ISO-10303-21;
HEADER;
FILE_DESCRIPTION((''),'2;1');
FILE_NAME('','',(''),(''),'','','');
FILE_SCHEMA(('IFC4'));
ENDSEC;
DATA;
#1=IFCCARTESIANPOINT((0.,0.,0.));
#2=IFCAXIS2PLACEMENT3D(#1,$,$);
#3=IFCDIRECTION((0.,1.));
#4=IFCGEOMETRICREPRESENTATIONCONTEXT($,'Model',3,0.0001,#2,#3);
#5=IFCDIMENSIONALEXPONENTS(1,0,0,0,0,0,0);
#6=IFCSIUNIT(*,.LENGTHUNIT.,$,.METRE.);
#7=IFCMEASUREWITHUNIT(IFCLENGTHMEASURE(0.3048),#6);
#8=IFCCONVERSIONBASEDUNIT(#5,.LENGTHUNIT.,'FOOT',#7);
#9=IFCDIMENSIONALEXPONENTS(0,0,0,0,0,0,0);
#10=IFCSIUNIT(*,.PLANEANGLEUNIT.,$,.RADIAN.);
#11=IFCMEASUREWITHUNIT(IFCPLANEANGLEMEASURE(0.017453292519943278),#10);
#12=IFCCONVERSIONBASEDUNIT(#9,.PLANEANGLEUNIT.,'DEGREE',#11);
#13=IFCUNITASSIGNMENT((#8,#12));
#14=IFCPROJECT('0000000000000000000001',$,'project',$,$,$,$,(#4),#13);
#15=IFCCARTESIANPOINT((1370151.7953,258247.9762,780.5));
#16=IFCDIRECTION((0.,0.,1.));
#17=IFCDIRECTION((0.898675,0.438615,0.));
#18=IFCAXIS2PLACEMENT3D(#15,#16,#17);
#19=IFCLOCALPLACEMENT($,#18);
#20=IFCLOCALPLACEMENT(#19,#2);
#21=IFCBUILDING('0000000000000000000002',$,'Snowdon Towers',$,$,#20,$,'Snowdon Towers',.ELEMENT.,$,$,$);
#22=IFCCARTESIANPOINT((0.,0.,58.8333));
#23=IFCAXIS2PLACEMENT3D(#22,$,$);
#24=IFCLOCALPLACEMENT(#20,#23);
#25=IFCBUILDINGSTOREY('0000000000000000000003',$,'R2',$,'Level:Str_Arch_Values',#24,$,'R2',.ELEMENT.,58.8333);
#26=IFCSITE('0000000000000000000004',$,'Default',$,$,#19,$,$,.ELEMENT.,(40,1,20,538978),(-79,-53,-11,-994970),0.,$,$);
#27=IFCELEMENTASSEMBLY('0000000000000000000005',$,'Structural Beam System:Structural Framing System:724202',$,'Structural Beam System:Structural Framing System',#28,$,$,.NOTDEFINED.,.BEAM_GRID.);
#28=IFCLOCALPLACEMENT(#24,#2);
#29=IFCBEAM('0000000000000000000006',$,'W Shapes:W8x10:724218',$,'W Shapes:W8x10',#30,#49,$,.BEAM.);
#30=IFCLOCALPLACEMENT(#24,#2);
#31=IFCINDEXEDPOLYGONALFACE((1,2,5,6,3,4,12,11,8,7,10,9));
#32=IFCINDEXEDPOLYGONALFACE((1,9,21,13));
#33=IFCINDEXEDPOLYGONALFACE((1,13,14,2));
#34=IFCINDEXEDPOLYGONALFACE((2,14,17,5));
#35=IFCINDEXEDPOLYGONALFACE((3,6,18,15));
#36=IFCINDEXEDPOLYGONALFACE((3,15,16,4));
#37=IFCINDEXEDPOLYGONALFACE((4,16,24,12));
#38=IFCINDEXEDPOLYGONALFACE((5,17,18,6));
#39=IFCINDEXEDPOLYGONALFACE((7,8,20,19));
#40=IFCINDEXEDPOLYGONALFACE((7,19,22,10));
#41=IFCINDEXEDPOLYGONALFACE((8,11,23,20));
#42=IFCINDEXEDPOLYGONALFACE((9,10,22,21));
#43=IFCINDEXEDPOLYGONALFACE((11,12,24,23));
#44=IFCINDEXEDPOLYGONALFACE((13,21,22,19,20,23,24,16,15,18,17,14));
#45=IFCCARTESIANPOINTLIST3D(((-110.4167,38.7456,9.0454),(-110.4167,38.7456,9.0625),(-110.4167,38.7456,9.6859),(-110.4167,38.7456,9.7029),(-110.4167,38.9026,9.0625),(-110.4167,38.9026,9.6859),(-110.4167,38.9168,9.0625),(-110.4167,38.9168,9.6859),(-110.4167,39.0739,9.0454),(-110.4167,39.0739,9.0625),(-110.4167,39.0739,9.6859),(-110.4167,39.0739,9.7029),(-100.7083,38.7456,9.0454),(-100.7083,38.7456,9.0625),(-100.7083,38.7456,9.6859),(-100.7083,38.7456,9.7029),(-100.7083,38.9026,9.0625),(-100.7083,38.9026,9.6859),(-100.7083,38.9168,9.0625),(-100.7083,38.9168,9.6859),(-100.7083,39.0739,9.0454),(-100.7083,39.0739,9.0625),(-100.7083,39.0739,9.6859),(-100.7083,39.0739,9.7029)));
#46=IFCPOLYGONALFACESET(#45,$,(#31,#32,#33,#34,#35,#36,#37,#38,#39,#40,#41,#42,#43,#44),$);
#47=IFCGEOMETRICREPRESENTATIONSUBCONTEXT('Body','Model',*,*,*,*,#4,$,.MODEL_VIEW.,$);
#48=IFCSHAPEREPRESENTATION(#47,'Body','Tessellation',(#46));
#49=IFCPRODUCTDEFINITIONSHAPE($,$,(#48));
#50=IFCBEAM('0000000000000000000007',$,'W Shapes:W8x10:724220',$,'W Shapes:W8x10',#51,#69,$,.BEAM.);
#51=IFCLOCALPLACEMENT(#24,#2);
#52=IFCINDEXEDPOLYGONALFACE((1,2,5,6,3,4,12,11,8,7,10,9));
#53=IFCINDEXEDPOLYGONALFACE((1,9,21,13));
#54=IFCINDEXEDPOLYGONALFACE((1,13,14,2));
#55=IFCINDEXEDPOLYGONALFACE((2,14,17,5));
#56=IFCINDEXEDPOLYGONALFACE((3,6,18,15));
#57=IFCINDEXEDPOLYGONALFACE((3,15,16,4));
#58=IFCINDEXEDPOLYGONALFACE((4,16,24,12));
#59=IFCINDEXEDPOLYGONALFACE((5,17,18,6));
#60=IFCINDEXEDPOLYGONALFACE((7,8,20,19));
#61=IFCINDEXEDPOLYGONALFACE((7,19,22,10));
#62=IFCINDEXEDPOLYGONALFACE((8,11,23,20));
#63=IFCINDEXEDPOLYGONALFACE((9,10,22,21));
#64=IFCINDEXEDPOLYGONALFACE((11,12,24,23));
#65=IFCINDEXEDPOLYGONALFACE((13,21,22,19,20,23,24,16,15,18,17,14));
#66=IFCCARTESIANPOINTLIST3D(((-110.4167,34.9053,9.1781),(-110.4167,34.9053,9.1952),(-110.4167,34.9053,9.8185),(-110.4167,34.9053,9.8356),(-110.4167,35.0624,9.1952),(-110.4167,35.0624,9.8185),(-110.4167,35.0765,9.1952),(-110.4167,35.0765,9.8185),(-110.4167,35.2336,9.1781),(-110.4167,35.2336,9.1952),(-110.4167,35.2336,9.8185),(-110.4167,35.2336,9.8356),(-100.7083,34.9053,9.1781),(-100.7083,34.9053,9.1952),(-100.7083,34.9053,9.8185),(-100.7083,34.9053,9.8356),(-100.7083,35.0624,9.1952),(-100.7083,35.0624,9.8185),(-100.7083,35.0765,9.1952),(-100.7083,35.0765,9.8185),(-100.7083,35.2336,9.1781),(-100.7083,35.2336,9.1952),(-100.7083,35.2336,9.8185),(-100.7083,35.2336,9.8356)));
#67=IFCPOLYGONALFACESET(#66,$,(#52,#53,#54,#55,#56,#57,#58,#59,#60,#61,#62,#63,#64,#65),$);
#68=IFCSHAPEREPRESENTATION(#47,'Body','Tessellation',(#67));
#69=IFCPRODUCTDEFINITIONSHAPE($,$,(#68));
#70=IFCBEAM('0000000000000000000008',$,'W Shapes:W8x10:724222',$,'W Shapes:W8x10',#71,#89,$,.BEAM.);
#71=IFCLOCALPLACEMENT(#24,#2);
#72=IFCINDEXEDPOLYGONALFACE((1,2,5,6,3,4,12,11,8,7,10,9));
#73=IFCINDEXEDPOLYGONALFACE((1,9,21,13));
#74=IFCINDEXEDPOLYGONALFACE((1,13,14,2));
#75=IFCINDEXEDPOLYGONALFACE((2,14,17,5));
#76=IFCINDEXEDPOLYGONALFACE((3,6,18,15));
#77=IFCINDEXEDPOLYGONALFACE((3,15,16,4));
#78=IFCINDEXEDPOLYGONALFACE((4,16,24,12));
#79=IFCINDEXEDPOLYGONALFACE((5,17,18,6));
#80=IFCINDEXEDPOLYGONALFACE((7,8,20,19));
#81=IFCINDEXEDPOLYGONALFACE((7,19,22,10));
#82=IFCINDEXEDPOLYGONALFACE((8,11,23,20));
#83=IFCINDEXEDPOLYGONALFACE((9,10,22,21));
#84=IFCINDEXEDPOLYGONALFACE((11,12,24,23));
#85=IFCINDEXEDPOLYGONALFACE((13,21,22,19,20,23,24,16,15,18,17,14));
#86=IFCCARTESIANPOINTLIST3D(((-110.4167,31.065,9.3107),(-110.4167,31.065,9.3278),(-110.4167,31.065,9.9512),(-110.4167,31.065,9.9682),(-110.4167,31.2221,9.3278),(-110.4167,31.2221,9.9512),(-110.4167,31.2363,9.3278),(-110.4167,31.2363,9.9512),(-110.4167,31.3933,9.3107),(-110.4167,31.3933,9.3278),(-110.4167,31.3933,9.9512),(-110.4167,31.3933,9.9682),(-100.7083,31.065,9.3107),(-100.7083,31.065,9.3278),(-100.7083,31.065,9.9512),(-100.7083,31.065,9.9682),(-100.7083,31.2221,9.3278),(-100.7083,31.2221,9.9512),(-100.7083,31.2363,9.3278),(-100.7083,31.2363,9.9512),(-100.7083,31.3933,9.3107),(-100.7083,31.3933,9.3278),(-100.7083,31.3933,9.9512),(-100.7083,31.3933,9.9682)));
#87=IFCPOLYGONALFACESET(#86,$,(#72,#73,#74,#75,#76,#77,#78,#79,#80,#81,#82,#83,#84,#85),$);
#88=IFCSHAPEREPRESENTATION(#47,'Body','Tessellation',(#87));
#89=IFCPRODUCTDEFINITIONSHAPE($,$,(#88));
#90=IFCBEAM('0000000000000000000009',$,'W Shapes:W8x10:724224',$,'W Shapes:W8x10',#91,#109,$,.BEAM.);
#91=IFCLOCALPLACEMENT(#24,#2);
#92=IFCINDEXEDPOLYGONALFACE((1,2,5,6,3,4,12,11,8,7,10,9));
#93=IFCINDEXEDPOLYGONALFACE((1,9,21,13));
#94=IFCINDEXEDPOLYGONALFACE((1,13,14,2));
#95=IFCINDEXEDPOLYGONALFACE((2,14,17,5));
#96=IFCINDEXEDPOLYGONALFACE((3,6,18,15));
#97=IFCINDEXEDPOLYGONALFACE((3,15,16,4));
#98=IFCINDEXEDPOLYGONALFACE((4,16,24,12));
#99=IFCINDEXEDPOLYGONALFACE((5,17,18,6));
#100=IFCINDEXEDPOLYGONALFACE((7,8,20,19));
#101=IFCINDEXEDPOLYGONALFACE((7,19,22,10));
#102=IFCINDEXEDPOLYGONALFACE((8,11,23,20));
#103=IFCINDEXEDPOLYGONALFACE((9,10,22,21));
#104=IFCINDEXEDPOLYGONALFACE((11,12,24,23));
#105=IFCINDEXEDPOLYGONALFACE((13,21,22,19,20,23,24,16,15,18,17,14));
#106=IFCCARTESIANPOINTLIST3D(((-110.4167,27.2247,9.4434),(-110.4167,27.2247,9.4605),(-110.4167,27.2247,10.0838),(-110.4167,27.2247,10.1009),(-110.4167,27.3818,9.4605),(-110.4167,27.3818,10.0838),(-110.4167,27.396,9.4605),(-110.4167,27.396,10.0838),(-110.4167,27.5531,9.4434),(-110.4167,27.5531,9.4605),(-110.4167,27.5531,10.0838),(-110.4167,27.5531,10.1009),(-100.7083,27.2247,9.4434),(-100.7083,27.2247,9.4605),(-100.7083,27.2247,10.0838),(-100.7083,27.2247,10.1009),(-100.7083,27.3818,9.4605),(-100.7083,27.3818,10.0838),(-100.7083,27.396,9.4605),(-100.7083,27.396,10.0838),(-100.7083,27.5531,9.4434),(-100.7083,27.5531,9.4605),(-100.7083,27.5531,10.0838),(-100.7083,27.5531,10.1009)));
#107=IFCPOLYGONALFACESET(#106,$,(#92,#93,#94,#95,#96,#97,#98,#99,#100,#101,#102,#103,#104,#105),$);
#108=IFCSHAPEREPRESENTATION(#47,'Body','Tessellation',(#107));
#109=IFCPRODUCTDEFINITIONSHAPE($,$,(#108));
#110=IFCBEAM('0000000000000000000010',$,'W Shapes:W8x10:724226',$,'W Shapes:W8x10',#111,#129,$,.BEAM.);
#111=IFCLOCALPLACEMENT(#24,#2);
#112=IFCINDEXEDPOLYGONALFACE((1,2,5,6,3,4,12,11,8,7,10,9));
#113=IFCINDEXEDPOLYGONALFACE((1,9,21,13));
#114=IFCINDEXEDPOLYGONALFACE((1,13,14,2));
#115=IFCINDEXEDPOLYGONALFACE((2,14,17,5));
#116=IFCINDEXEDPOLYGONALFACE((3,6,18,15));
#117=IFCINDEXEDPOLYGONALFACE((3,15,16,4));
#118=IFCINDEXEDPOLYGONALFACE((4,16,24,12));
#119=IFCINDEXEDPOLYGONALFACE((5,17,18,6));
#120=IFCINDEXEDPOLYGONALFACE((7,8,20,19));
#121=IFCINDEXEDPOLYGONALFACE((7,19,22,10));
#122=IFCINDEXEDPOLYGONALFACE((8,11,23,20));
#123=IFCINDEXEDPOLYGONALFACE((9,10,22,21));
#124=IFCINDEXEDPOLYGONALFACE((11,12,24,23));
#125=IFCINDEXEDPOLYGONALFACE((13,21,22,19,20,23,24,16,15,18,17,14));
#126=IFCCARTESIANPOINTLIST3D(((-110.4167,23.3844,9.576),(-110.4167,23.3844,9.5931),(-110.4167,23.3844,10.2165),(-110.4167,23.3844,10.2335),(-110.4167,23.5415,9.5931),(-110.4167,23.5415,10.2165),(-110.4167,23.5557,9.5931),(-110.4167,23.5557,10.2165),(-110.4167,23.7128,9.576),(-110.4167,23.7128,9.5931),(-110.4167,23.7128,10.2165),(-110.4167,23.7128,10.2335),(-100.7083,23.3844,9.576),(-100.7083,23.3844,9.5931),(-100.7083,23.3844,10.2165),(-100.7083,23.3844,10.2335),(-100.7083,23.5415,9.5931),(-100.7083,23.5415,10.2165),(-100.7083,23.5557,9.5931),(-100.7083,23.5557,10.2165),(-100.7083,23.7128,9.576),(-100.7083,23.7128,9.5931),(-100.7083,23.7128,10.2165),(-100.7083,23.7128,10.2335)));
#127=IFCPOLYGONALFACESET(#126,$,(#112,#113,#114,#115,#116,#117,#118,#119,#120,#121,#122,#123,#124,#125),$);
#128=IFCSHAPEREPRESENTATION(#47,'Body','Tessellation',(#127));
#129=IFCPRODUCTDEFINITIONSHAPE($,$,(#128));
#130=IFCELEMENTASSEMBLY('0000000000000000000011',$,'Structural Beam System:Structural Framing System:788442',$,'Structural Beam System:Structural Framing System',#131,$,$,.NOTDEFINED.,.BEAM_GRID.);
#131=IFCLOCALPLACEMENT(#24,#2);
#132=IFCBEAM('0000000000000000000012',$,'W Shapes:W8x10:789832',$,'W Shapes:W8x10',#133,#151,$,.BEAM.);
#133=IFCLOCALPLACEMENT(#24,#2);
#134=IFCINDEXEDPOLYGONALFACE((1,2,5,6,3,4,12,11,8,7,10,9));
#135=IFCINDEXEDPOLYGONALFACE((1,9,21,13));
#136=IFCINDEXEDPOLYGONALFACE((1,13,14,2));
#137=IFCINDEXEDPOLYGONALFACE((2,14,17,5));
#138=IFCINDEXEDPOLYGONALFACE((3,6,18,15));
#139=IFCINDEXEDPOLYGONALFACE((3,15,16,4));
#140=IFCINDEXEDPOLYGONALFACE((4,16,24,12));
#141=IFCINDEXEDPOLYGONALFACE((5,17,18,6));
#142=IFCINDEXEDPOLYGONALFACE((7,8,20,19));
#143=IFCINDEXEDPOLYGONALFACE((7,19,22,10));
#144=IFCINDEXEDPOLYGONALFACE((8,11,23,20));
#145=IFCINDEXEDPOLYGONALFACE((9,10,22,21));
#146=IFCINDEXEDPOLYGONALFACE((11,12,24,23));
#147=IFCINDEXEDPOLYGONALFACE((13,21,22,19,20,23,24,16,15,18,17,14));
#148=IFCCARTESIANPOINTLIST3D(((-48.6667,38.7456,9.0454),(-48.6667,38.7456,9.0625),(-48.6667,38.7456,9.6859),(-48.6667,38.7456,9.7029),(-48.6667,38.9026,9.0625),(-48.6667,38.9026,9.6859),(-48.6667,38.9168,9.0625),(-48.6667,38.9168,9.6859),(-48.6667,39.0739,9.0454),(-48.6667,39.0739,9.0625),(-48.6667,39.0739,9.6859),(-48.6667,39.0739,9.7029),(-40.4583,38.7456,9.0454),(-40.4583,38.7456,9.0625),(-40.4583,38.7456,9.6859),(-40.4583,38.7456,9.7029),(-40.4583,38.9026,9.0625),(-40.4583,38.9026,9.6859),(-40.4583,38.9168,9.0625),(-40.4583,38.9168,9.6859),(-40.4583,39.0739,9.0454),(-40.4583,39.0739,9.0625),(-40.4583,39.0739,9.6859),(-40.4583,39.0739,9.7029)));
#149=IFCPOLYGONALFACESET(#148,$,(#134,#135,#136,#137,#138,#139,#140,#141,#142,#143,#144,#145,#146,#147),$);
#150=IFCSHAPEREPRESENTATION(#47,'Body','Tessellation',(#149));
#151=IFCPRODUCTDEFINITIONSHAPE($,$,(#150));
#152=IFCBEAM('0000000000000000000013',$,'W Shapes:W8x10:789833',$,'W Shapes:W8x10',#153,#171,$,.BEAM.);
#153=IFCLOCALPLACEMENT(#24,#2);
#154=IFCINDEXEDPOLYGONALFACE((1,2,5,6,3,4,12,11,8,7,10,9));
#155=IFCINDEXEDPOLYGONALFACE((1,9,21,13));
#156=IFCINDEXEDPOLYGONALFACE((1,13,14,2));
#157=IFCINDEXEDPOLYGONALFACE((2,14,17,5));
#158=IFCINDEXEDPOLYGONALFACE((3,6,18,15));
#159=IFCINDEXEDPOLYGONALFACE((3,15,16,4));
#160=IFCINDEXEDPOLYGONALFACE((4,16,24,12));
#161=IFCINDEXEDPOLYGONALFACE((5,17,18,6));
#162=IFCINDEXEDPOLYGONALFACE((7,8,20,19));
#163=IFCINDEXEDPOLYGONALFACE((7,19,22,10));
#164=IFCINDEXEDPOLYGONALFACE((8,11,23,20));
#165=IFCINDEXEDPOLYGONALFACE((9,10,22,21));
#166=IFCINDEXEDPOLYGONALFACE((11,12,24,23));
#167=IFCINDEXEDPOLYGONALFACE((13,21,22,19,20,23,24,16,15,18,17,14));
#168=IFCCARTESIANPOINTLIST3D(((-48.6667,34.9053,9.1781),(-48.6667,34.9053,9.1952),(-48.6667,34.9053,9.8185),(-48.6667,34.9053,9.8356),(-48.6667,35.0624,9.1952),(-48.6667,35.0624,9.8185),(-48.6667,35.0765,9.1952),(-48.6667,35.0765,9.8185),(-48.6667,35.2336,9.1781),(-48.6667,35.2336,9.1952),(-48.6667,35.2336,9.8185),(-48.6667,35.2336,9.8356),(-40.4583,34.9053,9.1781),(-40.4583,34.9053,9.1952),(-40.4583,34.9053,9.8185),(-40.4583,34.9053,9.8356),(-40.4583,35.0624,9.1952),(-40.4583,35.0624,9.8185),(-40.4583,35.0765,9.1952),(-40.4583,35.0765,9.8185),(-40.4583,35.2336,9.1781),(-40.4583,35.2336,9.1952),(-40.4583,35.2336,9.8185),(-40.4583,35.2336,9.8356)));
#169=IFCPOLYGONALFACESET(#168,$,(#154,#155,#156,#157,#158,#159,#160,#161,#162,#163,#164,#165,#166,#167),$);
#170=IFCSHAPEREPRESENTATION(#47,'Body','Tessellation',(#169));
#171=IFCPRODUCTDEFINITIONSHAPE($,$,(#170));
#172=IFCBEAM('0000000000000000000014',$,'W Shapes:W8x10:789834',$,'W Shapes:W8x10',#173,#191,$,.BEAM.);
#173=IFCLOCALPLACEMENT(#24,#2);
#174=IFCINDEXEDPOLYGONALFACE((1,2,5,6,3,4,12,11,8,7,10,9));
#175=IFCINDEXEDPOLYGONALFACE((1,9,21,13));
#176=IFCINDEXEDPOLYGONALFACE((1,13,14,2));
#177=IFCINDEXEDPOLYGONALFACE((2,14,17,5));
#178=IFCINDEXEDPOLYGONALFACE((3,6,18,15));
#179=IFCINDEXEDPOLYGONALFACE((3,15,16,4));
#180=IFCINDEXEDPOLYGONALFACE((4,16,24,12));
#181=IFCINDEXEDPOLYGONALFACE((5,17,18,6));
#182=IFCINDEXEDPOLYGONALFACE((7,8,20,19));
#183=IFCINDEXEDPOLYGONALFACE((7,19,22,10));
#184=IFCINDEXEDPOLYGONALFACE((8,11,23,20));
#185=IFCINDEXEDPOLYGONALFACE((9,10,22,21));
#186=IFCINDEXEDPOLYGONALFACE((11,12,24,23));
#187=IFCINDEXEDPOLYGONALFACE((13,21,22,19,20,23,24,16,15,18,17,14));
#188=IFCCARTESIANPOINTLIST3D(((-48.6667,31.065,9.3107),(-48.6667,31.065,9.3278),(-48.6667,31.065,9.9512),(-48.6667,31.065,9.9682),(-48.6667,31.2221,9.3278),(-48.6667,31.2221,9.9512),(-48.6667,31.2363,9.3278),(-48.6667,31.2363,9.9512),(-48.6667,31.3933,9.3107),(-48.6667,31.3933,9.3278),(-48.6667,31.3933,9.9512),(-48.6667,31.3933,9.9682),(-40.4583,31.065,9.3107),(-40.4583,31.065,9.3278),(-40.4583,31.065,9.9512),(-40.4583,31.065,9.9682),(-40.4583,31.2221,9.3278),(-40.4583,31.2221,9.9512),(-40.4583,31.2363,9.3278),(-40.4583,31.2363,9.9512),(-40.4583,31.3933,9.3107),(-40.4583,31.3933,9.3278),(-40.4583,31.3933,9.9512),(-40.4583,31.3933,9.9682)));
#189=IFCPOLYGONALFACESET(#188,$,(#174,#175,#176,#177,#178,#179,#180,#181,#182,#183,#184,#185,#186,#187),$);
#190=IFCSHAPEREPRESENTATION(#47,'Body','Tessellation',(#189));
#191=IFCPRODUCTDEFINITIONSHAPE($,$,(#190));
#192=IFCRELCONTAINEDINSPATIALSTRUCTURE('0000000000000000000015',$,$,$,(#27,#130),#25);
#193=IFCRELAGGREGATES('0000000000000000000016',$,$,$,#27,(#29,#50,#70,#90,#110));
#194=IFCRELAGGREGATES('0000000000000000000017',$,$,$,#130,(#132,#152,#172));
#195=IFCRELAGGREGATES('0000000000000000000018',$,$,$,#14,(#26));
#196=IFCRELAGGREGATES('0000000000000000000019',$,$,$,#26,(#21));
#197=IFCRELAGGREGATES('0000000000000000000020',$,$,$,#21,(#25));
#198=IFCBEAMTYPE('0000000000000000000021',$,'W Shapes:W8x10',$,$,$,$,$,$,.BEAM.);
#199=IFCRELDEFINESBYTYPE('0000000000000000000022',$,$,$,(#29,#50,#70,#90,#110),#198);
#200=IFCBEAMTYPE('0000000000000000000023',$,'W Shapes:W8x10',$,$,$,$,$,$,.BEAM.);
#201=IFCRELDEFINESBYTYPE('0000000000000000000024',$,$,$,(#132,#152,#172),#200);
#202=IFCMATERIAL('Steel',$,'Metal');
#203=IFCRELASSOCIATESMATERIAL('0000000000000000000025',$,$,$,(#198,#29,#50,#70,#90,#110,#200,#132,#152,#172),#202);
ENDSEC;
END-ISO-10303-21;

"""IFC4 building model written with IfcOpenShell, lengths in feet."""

from ifc_helpers import new_model, entity, si_unit, converted_unit, direction, frame, origin, place, context, subcontext, project, spatial, indexed_curve, outline, extrude, source, transform, mapped, material, type_object, type_shapes, element, aggregate, save


model = new_model("IFC4")

# Units and contexts
model_context = context("Model", 3, precision=0.0001, world=origin(), true_north=direction((0.0, 1.0)))
body_context = subcontext(model_context, "Body", "Model", "MODEL_VIEW")
ifc_project = project(units=[converted_unit("LENGTHUNIT", "FOOT", entity("IfcLengthMeasure", 0.3048), si_unit("LENGTHUNIT", "METRE"), dimensions=[1, 0, 0, 0, 0, 0, 0]), converted_unit("PLANEANGLEUNIT", "DEGREE", entity("IfcPlaneAngleMeasure", 0.017453292519943278), si_unit("PLANEANGLEUNIT", "RADIAN"), dimensions=[0, 0, 0, 0, 0, 0, 0])], contexts=[model_context])

# Site, building, storey
site_placement = place(None, frame((1370151.7953, 258247.9762, 780.5), z_axis=(0.0, 0.0, 1.0), x_axis=(0.898675, 0.438615, 0.0)))
site = spatial("IfcSite", under=ifc_project, at=site_placement, Name="Default", CompositionType="ELEMENT", RefLatitude=(40, 1, 20, 538978), RefLongitude=(-79, -53, -11, -994970), RefElevation=0.0)
building_placement = place(site_placement, origin())
building = spatial("IfcBuilding", under=site, at=building_placement, Name="Snowdon Towers", LongName="Snowdon Towers", CompositionType="ELEMENT")
storey_placement = place(building_placement, frame((0.0, 0.0, 58.8333)))
storey = spatial("IfcBuildingStorey", under=building, at=storey_placement, Name="R2", ObjectType="Level:Str_Arch_Values", LongName="R2", CompositionType="ELEMENT", Elevation=58.8333)

# Element assemblies, beams
assembly_1_placement = place(storey_placement, origin())
assembly_1 = element("IfcElementAssembly", 1, at=assembly_1_placement, inside=storey, Name="Structural Beam System:Structural Framing System:724202", ObjectType="Structural Beam System:Structural Framing System", AssemblyPlace="NOTDEFINED", PredefinedType="BEAM_GRID")
ifc_material_1 = material(Name="Steel", Category="Metal")
beam_type_1 = type_object("IfcBeamType", Name="W Shapes:W8x10", PredefinedType="BEAM", material=ifc_material_1)
shared_shape_1 = source(origin(), body_context, "Body", "SweptSolid", [
    extrude(outline(indexed_curve([(-0.1642, -0.3117), (-0.1642, -0.3288), (0.1642, -0.3288), (0.1642, -0.3117), (0.0071, -0.3117), (0.0071, 0.3117), (0.1642, 0.3117), (0.1642, 0.3287), (-0.1642, 0.3287), (-0.1642, 0.3117), (-0.0071, 0.3117), (-0.0071, -0.3117), (-0.1642, -0.3117)], self_intersect=False)), frame((-4.8542, 0.0, 0.0), z_axis=(-1.0, 0.0, 0.0), x_axis=(0.0, -1.0, 0.0)), (0.0, 0.0, -1.0), 9.7083),
])
type_shapes(beam_type_1, [shared_shape_1])
beam_1_placement = place(assembly_1_placement, frame((-105.5625, 38.9097, 9.3742)))
beam_1 = element("IfcBeam", 2, at=beam_1_placement, type_object=beam_type_1, material=ifc_material_1, Name="W Shapes:W8x10:724218", ObjectType="W Shapes:W8x10", PredefinedType="BEAM", context=body_context, shape_type="MappedRepresentation", body=[
    mapped(shared_shape_1, transform((0.0, 0.0, 0.0), scale=1.0)),
])
beam_2_placement = place(assembly_1_placement, frame((-105.5625, 35.0694, 9.5068)))
beam_2 = element("IfcBeam", 3, at=beam_2_placement, type_object=beam_type_1, material=ifc_material_1, Name="W Shapes:W8x10:724220", ObjectType="W Shapes:W8x10", PredefinedType="BEAM", context=body_context, shape_type="MappedRepresentation", body=[
    mapped(shared_shape_1, transform((0.0, 0.0, 0.0), scale=1.0)),
])
beam_3_placement = place(assembly_1_placement, frame((-105.5625, 31.2292, 9.6395)))
beam_3 = element("IfcBeam", 4, at=beam_3_placement, type_object=beam_type_1, material=ifc_material_1, Name="W Shapes:W8x10:724222", ObjectType="W Shapes:W8x10", PredefinedType="BEAM", context=body_context, shape_type="MappedRepresentation", body=[
    mapped(shared_shape_1, transform((0.0, 0.0, 0.0), scale=1.0)),
])
beam_4_placement = place(assembly_1_placement, frame((-105.5625, 27.3889, 9.7721)))
beam_4 = element("IfcBeam", 5, at=beam_4_placement, type_object=beam_type_1, material=ifc_material_1, Name="W Shapes:W8x10:724224", ObjectType="W Shapes:W8x10", PredefinedType="BEAM", context=body_context, shape_type="MappedRepresentation", body=[
    mapped(shared_shape_1, transform((0.0, 0.0, 0.0), scale=1.0)),
])
beam_5_placement = place(assembly_1_placement, frame((-105.5625, 23.5486, 9.9048)))
beam_5 = element("IfcBeam", 6, at=beam_5_placement, type_object=beam_type_1, material=ifc_material_1, Name="W Shapes:W8x10:724226", ObjectType="W Shapes:W8x10", PredefinedType="BEAM", context=body_context, shape_type="MappedRepresentation", body=[
    mapped(shared_shape_1, transform((0.0, 0.0, 0.0), scale=1.0)),
])
aggregate(assembly_1, [beam_1, beam_2, beam_3, beam_4, beam_5])
assembly_2_placement = place(storey_placement, origin())
assembly_2 = element("IfcElementAssembly", 7, at=assembly_2_placement, inside=storey, Name="Structural Beam System:Structural Framing System:788442", ObjectType="Structural Beam System:Structural Framing System", AssemblyPlace="NOTDEFINED", PredefinedType="BEAM_GRID")
beam_type_2 = type_object("IfcBeamType", Name="W Shapes:W8x10", PredefinedType="BEAM", material=ifc_material_1)
shared_shape_2 = source(origin(), body_context, "Body", "SweptSolid", [
    extrude(outline(indexed_curve([(-0.1642, -0.3117), (-0.1642, -0.3288), (0.1642, -0.3288), (0.1642, -0.3117), (0.0071, -0.3117), (0.0071, 0.3117), (0.1642, 0.3117), (0.1642, 0.3287), (-0.1642, 0.3287), (-0.1642, 0.3117), (-0.0071, 0.3117), (-0.0071, -0.3117), (-0.1642, -0.3117)], self_intersect=False)), frame((-4.1042, 0.0, 0.0), z_axis=(-1.0, 0.0, 0.0), x_axis=(0.0, -1.0, 0.0)), (0.0, 0.0, -1.0), 8.2083),
])
type_shapes(beam_type_2, [shared_shape_2])
beam_6_placement = place(assembly_2_placement, frame((-44.5625, 38.9097, 9.3742)))
beam_6 = element("IfcBeam", 8, at=beam_6_placement, type_object=beam_type_2, material=ifc_material_1, Name="W Shapes:W8x10:789832", ObjectType="W Shapes:W8x10", PredefinedType="BEAM", context=body_context, shape_type="MappedRepresentation", body=[
    mapped(shared_shape_2, transform((0.0, 0.0, 0.0), scale=1.0)),
])
beam_7_placement = place(assembly_2_placement, frame((-44.5625, 35.0694, 9.5068)))
beam_7 = element("IfcBeam", 9, at=beam_7_placement, type_object=beam_type_2, material=ifc_material_1, Name="W Shapes:W8x10:789833", ObjectType="W Shapes:W8x10", PredefinedType="BEAM", context=body_context, shape_type="MappedRepresentation", body=[
    mapped(shared_shape_2, transform((0.0, 0.0, 0.0), scale=1.0)),
])
beam_8_placement = place(assembly_2_placement, frame((-44.5625, 31.2292, 9.6395)))
beam_8 = element("IfcBeam", 10, at=beam_8_placement, type_object=beam_type_2, material=ifc_material_1, Name="W Shapes:W8x10:789834", ObjectType="W Shapes:W8x10", PredefinedType="BEAM", context=body_context, shape_type="MappedRepresentation", body=[
    mapped(shared_shape_2, transform((0.0, 0.0, 0.0), scale=1.0)),
])
aggregate(assembly_2, [beam_6, beam_7, beam_8])

save(model, "model.ifc")
